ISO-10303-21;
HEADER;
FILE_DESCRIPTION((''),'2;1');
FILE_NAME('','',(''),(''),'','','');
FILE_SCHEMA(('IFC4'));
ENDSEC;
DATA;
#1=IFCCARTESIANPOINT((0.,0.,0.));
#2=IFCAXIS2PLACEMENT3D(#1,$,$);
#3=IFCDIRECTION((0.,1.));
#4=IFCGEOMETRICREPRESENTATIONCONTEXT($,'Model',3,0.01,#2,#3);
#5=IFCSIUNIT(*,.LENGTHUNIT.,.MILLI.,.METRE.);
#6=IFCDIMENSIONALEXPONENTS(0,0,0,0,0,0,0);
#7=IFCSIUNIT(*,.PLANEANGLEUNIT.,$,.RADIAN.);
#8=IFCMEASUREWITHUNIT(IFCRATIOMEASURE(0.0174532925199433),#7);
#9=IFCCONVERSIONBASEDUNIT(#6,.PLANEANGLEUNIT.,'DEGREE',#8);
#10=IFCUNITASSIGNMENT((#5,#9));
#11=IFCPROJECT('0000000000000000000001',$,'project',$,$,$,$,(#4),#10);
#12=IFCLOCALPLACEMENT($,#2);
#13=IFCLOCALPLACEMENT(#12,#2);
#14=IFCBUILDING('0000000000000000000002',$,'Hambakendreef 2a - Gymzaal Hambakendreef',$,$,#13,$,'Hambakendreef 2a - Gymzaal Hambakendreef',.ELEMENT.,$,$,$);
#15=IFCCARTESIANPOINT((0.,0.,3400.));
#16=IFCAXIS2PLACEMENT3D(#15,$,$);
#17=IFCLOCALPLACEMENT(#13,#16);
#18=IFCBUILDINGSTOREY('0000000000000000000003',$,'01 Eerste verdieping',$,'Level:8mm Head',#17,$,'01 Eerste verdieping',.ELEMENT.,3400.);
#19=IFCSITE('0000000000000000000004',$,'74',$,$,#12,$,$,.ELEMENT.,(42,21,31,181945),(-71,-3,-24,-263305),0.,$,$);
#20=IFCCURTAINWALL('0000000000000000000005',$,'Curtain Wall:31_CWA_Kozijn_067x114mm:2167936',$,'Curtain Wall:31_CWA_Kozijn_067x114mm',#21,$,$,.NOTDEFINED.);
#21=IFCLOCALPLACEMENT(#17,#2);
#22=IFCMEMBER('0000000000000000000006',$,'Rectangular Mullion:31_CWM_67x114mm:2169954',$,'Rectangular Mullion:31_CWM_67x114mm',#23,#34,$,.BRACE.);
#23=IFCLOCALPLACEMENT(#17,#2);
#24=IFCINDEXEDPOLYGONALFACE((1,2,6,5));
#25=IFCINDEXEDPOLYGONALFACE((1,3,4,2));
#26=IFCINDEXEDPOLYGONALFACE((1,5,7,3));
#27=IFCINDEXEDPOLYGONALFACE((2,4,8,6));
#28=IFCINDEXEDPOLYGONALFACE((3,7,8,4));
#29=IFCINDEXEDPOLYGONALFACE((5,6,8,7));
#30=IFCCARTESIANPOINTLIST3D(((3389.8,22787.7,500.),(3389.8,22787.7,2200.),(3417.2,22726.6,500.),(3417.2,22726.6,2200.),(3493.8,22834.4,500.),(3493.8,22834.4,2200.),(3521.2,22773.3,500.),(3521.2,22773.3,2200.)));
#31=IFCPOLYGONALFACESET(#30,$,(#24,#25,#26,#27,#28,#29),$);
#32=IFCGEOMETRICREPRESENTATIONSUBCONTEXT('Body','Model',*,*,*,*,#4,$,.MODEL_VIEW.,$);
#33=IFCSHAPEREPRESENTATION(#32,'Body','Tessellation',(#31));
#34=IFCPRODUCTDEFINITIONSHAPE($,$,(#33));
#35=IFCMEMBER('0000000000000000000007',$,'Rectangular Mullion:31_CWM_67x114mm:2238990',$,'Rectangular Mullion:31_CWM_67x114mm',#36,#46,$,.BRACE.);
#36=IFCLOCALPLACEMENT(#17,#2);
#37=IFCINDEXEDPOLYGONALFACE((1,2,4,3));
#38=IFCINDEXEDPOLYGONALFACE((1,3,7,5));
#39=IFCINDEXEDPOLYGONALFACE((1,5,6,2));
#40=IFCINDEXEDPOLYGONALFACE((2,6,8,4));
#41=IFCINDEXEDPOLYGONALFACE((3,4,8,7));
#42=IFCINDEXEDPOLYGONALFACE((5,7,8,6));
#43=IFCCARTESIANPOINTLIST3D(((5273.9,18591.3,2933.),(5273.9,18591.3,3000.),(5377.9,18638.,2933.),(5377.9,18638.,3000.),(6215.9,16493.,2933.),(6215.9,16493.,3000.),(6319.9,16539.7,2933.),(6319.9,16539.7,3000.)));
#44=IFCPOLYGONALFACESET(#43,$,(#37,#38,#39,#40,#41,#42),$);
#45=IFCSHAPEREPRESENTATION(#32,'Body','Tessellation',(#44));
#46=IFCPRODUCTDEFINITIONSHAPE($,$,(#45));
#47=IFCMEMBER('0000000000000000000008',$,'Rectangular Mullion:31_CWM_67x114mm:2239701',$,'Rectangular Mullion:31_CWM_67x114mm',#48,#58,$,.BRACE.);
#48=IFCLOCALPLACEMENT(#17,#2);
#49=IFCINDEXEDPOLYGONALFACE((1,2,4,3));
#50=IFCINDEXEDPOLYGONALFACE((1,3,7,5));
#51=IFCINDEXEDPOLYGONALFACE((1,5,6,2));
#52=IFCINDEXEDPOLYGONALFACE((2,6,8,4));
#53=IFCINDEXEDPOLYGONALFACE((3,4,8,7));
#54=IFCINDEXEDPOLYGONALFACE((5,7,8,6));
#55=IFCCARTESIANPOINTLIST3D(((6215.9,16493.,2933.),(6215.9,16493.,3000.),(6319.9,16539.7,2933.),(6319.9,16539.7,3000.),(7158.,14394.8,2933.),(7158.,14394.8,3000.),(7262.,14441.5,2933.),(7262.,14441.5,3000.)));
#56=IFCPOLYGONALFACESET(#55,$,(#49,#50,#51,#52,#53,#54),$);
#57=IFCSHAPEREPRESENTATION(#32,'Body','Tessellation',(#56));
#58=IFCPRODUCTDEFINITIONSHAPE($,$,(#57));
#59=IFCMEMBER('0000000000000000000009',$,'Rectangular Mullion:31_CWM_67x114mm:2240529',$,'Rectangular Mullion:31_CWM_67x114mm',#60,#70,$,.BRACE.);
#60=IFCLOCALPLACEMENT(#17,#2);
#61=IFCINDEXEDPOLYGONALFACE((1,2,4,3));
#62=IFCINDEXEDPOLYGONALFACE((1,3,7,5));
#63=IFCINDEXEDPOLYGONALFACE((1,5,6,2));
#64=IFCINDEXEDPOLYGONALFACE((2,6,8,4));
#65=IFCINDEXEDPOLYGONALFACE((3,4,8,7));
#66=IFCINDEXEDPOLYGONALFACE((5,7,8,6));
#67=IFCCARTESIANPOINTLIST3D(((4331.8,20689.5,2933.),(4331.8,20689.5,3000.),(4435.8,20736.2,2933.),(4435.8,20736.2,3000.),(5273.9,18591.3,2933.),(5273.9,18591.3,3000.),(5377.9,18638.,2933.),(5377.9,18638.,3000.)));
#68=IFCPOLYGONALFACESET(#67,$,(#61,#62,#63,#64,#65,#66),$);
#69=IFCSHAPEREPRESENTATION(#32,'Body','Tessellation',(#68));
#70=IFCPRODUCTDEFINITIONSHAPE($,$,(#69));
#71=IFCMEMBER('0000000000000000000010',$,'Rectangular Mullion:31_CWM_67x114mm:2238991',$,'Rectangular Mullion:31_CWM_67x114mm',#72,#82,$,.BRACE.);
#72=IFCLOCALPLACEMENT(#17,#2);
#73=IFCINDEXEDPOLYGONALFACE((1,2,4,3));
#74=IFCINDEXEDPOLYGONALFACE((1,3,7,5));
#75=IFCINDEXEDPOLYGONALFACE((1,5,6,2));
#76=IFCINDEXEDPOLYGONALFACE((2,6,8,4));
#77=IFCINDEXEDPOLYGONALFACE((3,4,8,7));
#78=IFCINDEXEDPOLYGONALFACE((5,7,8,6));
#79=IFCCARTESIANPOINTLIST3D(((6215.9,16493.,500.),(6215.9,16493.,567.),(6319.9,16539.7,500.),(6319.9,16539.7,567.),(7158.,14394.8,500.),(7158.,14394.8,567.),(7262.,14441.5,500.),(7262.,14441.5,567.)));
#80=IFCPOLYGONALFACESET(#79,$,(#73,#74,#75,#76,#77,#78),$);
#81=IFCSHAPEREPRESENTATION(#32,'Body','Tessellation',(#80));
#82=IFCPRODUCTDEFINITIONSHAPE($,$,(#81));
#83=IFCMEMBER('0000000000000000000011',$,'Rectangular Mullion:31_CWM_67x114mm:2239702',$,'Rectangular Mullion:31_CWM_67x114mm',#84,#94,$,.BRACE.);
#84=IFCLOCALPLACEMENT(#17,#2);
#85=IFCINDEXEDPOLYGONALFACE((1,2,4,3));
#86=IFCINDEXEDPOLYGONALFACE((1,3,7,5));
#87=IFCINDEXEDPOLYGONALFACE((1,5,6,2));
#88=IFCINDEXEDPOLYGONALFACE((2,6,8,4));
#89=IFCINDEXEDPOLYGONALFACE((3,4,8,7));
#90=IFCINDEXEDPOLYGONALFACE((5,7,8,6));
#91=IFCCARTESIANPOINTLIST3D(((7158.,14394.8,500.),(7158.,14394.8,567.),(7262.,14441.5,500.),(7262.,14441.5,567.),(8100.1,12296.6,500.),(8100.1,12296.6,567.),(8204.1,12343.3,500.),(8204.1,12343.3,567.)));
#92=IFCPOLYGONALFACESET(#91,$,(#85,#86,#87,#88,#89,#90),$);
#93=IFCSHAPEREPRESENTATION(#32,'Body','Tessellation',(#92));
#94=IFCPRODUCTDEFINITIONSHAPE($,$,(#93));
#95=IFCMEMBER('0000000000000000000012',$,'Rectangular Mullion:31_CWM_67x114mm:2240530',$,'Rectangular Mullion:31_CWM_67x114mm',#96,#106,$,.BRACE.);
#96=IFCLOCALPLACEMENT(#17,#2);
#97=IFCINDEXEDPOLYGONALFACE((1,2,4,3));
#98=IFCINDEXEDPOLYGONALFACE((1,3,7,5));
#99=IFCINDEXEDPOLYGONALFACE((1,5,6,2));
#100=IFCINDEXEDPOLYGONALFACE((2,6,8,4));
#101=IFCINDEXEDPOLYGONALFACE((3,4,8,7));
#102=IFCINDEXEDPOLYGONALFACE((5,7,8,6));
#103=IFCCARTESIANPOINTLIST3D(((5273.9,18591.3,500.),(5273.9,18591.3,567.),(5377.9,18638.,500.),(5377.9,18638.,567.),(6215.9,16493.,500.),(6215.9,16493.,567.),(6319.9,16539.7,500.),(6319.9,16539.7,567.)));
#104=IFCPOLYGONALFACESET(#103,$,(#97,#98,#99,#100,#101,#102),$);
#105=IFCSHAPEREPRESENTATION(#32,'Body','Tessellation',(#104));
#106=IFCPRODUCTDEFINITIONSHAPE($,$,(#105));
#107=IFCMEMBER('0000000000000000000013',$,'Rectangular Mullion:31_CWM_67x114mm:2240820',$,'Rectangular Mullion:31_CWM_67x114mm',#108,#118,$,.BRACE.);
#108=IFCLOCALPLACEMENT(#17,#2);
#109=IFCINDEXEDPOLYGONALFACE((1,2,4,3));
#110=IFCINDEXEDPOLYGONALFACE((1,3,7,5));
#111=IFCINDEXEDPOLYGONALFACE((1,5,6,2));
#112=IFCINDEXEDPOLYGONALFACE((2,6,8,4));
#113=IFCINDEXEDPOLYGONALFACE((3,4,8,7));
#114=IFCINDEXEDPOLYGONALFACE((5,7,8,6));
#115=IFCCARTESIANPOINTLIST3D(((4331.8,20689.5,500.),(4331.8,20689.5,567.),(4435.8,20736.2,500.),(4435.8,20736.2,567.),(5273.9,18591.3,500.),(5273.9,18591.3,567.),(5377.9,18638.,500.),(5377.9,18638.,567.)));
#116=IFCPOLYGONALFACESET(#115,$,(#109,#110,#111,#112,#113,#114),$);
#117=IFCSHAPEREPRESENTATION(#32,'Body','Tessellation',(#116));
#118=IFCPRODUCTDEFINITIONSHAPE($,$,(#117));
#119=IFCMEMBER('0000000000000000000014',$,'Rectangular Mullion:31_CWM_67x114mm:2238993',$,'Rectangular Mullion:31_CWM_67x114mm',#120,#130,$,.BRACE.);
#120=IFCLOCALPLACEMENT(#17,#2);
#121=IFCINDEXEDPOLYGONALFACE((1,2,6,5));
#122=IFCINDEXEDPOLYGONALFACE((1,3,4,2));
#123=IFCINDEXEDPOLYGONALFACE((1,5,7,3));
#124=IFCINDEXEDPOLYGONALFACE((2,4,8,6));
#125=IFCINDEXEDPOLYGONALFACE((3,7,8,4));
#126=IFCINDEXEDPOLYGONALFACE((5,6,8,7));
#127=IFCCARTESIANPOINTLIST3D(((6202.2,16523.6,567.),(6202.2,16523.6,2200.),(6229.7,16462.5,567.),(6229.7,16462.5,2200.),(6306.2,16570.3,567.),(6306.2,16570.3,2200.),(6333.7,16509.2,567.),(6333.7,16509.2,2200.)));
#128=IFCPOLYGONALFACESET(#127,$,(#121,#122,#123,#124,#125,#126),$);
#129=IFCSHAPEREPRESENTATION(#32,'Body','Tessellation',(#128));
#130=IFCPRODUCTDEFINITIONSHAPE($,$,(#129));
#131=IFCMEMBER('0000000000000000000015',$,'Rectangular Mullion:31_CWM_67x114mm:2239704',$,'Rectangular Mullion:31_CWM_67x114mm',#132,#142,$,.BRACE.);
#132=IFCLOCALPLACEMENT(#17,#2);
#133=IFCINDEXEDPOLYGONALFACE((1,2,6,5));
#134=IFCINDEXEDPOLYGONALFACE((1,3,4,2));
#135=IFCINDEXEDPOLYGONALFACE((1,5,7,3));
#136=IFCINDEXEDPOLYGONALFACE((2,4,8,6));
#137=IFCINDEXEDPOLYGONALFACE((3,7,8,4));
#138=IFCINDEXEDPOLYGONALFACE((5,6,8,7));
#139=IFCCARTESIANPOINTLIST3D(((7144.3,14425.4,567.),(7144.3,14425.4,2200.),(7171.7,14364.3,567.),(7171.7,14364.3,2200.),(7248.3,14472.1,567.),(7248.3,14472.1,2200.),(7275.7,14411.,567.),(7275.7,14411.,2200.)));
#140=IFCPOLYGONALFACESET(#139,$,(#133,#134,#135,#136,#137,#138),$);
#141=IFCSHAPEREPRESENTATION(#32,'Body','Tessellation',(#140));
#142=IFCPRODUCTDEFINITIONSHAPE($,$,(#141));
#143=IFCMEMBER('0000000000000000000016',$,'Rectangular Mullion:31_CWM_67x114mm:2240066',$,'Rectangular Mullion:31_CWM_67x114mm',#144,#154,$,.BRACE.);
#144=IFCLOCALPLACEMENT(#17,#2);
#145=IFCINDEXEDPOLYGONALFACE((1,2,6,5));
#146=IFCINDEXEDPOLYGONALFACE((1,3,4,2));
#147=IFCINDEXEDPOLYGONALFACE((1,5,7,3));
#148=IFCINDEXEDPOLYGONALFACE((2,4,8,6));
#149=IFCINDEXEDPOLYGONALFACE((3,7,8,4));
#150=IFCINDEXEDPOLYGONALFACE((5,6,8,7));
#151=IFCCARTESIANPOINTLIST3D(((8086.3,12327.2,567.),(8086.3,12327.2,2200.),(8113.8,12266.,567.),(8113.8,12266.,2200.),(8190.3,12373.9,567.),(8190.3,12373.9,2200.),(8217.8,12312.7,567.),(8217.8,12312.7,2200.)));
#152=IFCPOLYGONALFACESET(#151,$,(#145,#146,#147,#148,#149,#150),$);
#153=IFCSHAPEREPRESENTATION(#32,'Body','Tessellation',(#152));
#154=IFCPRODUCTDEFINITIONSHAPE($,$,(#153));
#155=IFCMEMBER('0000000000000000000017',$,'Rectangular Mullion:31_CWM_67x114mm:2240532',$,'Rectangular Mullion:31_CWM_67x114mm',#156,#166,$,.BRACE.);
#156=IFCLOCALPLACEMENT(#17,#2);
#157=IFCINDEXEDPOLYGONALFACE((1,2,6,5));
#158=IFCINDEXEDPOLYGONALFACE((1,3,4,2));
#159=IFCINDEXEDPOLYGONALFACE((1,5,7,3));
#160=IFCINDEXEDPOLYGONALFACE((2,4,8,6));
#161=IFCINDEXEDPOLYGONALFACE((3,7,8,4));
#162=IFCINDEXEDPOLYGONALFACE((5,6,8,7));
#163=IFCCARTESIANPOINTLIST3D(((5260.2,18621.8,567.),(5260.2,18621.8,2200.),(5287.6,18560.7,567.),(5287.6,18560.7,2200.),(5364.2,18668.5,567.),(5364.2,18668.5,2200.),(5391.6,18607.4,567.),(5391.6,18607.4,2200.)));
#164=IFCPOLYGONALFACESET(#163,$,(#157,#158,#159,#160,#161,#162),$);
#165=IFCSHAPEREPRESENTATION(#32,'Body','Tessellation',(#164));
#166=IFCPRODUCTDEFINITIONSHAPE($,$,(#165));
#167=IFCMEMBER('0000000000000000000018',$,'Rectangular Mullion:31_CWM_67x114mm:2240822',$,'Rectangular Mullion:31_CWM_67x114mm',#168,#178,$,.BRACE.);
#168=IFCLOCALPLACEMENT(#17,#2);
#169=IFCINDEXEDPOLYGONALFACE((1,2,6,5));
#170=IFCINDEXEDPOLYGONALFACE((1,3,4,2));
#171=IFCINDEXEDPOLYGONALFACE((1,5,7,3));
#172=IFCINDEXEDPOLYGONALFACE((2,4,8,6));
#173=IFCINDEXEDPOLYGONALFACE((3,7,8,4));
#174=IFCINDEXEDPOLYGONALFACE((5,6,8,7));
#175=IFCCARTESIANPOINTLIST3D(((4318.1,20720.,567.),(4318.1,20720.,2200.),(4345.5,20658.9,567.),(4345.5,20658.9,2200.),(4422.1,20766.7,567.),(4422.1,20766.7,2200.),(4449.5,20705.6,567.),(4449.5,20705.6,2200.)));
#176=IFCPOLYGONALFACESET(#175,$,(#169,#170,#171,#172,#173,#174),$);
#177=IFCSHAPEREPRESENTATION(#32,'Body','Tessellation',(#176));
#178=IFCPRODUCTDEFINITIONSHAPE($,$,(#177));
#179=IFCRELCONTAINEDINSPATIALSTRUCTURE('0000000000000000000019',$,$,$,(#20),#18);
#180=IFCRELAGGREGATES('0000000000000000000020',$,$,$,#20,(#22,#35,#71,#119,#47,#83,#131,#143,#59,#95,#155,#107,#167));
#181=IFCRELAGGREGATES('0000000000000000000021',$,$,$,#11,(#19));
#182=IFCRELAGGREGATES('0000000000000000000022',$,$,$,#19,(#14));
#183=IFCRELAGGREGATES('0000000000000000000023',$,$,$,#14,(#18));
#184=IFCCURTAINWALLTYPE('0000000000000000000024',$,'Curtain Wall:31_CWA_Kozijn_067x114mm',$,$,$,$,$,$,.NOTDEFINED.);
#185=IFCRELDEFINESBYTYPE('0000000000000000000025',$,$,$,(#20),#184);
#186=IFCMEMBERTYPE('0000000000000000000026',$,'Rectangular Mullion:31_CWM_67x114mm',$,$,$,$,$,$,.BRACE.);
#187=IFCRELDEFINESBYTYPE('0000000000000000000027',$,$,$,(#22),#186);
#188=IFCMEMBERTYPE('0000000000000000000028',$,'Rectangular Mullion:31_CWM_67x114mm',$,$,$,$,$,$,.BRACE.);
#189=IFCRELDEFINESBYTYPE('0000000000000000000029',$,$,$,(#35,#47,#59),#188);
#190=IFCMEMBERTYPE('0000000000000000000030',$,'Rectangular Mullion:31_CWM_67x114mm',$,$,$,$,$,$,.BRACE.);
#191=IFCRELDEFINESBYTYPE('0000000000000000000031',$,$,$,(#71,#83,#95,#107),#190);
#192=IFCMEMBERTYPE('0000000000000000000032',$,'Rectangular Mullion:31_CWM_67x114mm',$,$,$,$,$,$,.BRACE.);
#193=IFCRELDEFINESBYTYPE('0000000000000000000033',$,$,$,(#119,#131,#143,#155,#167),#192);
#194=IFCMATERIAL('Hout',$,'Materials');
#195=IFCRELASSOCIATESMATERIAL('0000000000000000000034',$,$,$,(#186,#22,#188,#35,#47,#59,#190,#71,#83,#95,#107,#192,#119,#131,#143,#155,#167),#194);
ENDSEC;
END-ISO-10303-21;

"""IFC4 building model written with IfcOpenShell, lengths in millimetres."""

from ifc_helpers import new_model, entity, si_unit, converted_unit, direction, frame, origin, place, context, subcontext, project, spatial, indexed_curve, outline, extrude, source, transform, mapped, material, type_object, type_shapes, element, aggregate, save


model = new_model("IFC4")

# Units and contexts
model_context = context("Model", 3, precision=0.01, world=origin(), true_north=direction((0.0, 1.0)))
body_context = subcontext(model_context, "Body", "Model", "MODEL_VIEW")
ifc_project = project(units=[si_unit("LENGTHUNIT", "METRE", prefix="MILLI"), converted_unit("PLANEANGLEUNIT", "DEGREE", entity("IfcRatioMeasure", 0.0174532925199433), si_unit("PLANEANGLEUNIT", "RADIAN"), dimensions=[0, 0, 0, 0, 0, 0, 0])], contexts=[model_context])

# Site, building, storey
site_placement = place(None, origin())
site = spatial("IfcSite", under=ifc_project, at=site_placement, Name="74", CompositionType="ELEMENT", RefLatitude=(42, 21, 31, 181945), RefLongitude=(-71, -3, -24, -263305), RefElevation=0.0)
building_placement = place(site_placement, origin())
building = spatial("IfcBuilding", under=site, at=building_placement, Name="Hambakendreef 2a - Gymzaal Hambakendreef", LongName="Hambakendreef 2a - Gymzaal Hambakendreef", CompositionType="ELEMENT")
storey_placement = place(building_placement, frame((0.0, 0.0, 3400.0)))
storey = spatial("IfcBuildingStorey", under=building, at=storey_placement, Name="01 Eerste verdieping", ObjectType="Level:8mm Head", LongName="01 Eerste verdieping", CompositionType="ELEMENT", Elevation=3400.0)

# Curtain wall, members
curtain_wall_type = type_object("IfcCurtainWallType", Name="Curtain Wall:31_CWA_Kozijn_067x114mm", PredefinedType="NOTDEFINED")
curtain_wall_placement = place(storey_placement, frame((0.0, 0.0, -3400.0)))
curtain_wall = element("IfcCurtainWall", 1, at=curtain_wall_placement, inside=storey, type_object=curtain_wall_type, Name="Curtain Wall:31_CWA_Kozijn_067x114mm:2167936", ObjectType="Curtain Wall:31_CWA_Kozijn_067x114mm", PredefinedType="NOTDEFINED")
ifc_material_1 = material(Name="Hout", Category="Materials")
member_type_1 = type_object("IfcMemberType", Name="Rectangular Mullion:31_CWM_67x114mm", PredefinedType="BRACE", material=ifc_material_1)
shared_shape_1 = source(origin(), body_context, "Body", "SweptSolid", [
    extrude(outline(indexed_curve([(-57.0, -33.5), (57.0, -33.5), (57.0, 33.5), (-57.0, 33.5), (-57.0, -33.5)], self_intersect=False)), frame((-33.5, 0.0, -1700.0), z_axis=(0.0, 0.0, 1.0), x_axis=(0.0, -1.0, 0.0)), (0.0, 0.0, 1.0), 1700.0),
])
type_shapes(member_type_1, [shared_shape_1])
member_1_placement = place(storey_placement, frame((3441.8, 22811.0, 2200.0), z_axis=(0.0, 0.0, 1.0), x_axis=(-0.40959, 0.91227, 0.0)))
member_1 = element("IfcMember", 2, at=member_1_placement, type_object=member_type_1, material=ifc_material_1, Name="Rectangular Mullion:31_CWM_67x114mm:2169954", ObjectType="Rectangular Mullion:31_CWM_67x114mm", PredefinedType="BRACE", context=body_context, shape_type="MappedRepresentation", body=[
    mapped(shared_shape_1, transform((0.0, 0.0, 0.0), scale=1.0)),
])
member_type_2 = type_object("IfcMemberType", Name="Rectangular Mullion:31_CWM_67x114mm", PredefinedType="BRACE", material=ifc_material_1)
shared_shape_2 = source(origin(), body_context, "Body", "SweptSolid", [
    extrude(outline(indexed_curve([(-57.0, -33.5), (57.0, -33.5), (57.0, 33.5), (-57.0, 33.5), (-57.0, -33.5)], self_intersect=False)), frame((-33.5, 0.0, -2300.0), z_axis=(0.0, 0.0, 1.0), x_axis=(0.0, -1.0, 0.0)), (0.0, 0.0, 1.0), 2300.0),
])
type_shapes(member_type_2, [shared_shape_2])
member_2_placement = place(storey_placement, frame((6267.9, 16516.4, 3000.0), z_axis=(0.40959, -0.91227, 0.0), x_axis=(0.0, 0.0, 1.0)))
member_2 = element("IfcMember", 3, at=member_2_placement, type_object=member_type_2, material=ifc_material_1, Name="Rectangular Mullion:31_CWM_67x114mm:2238990", ObjectType="Rectangular Mullion:31_CWM_67x114mm", PredefinedType="BRACE", context=body_context, shape_type="MappedRepresentation", body=[
    mapped(shared_shape_2, transform((0.0, 0.0, 0.0), scale=1.0)),
])
member_3_placement = place(storey_placement, frame((7210.0, 14418.2, 3000.0), z_axis=(0.40959, -0.91227, 0.0), x_axis=(0.0, 0.0, 1.0)))
member_3 = element("IfcMember", 4, at=member_3_placement, type_object=member_type_2, material=ifc_material_1, Name="Rectangular Mullion:31_CWM_67x114mm:2239701", ObjectType="Rectangular Mullion:31_CWM_67x114mm", PredefinedType="BRACE", context=body_context, shape_type="MappedRepresentation", body=[
    mapped(shared_shape_2, transform((0.0, 0.0, 0.0), scale=1.0)),
])
member_4_placement = place(storey_placement, frame((5325.9, 18614.6, 3000.0), z_axis=(0.40959, -0.91227, 0.0), x_axis=(0.0, 0.0, 1.0)))
member_4 = element("IfcMember", 5, at=member_4_placement, type_object=member_type_2, material=ifc_material_1, Name="Rectangular Mullion:31_CWM_67x114mm:2240529", ObjectType="Rectangular Mullion:31_CWM_67x114mm", PredefinedType="BRACE", context=body_context, shape_type="MappedRepresentation", body=[
    mapped(shared_shape_2, transform((0.0, 0.0, 0.0), scale=1.0)),
])
member_type_3 = type_object("IfcMemberType", Name="Rectangular Mullion:31_CWM_67x114mm", PredefinedType="BRACE", material=ifc_material_1)
shared_shape_3 = source(origin(), body_context, "Body", "SweptSolid", [
    extrude(outline(indexed_curve([(-57.0, -33.5), (57.0, -33.5), (57.0, 33.5), (-57.0, 33.5), (-57.0, -33.5)], self_intersect=False)), frame((-33.5, 0.0, -2300.0), z_axis=(0.0, 0.0, 1.0), x_axis=(0.0, -1.0, 0.0)), (0.0, 0.0, 1.0), 2300.0),
])
type_shapes(member_type_3, [shared_shape_3])
member_5_placement = place(storey_placement, frame((6267.9, 16516.4, 500.0), z_axis=(-0.40959, 0.91227, 0.0), x_axis=(0.0, 0.0, -1.0)))
member_5 = element("IfcMember", 6, at=member_5_placement, type_object=member_type_3, material=ifc_material_1, Name="Rectangular Mullion:31_CWM_67x114mm:2238991", ObjectType="Rectangular Mullion:31_CWM_67x114mm", PredefinedType="BRACE", context=body_context, shape_type="MappedRepresentation", body=[
    mapped(shared_shape_3, transform((0.0, 0.0, 0.0), scale=1.0)),
])
member_6_placement = place(storey_placement, frame((7210.0, 14418.2, 500.0), z_axis=(-0.40959, 0.91227, 0.0), x_axis=(0.0, 0.0, -1.0)))
member_6 = element("IfcMember", 7, at=member_6_placement, type_object=member_type_3, material=ifc_material_1, Name="Rectangular Mullion:31_CWM_67x114mm:2239702", ObjectType="Rectangular Mullion:31_CWM_67x114mm", PredefinedType="BRACE", context=body_context, shape_type="MappedRepresentation", body=[
    mapped(shared_shape_3, transform((0.0, 0.0, 0.0), scale=1.0)),
])
member_7_placement = place(storey_placement, frame((5325.9, 18614.6, 500.0), z_axis=(-0.40959, 0.91227, 0.0), x_axis=(0.0, 0.0, -1.0)))
member_7 = element("IfcMember", 8, at=member_7_placement, type_object=member_type_3, material=ifc_material_1, Name="Rectangular Mullion:31_CWM_67x114mm:2240530", ObjectType="Rectangular Mullion:31_CWM_67x114mm", PredefinedType="BRACE", context=body_context, shape_type="MappedRepresentation", body=[
    mapped(shared_shape_3, transform((0.0, 0.0, 0.0), scale=1.0)),
])
member_8_placement = place(storey_placement, frame((4383.8, 20712.8, 500.0), z_axis=(-0.40959, 0.91227, 0.0), x_axis=(0.0, 0.0, -1.0)))
member_8 = element("IfcMember", 9, at=member_8_placement, type_object=member_type_3, material=ifc_material_1, Name="Rectangular Mullion:31_CWM_67x114mm:2240820", ObjectType="Rectangular Mullion:31_CWM_67x114mm", PredefinedType="BRACE", context=body_context, shape_type="MappedRepresentation", body=[
    mapped(shared_shape_3, transform((0.0, 0.0, 0.0), scale=1.0)),
])
member_type_4 = type_object("IfcMemberType", Name="Rectangular Mullion:31_CWM_67x114mm", PredefinedType="BRACE", material=ifc_material_1)
shared_shape_4 = source(origin(), body_context, "Body", "SweptSolid", [
    extrude(outline(indexed_curve([(-57.0, -33.5), (57.0, -33.5), (57.0, 33.5), (-57.0, 33.5), (-57.0, -33.5)], self_intersect=False)), frame((0.0, 0.0, -1633.0), z_axis=(0.0, 0.0, 1.0), x_axis=(0.0, -1.0, 0.0)), (0.0, 0.0, 1.0), 1633.0),
])
type_shapes(member_type_4, [shared_shape_4])
member_9_placement = place(storey_placement, frame((6267.9, 16516.4, 567.0), z_axis=(0.0, 0.0, -1.0), x_axis=(0.40959, -0.91227, 0.0)))
member_9 = element("IfcMember", 10, at=member_9_placement, type_object=member_type_4, material=ifc_material_1, Name="Rectangular Mullion:31_CWM_67x114mm:2238993", ObjectType="Rectangular Mullion:31_CWM_67x114mm", PredefinedType="BRACE", context=body_context, shape_type="MappedRepresentation", body=[
    mapped(shared_shape_4, transform((0.0, 0.0, 0.0), scale=1.0)),
])
member_10_placement = place(storey_placement, frame((7210.0, 14418.2, 567.0), z_axis=(0.0, 0.0, -1.0), x_axis=(0.40959, -0.91227, 0.0)))
member_10 = element("IfcMember", 11, at=member_10_placement, type_object=member_type_4, material=ifc_material_1, Name="Rectangular Mullion:31_CWM_67x114mm:2239704", ObjectType="Rectangular Mullion:31_CWM_67x114mm", PredefinedType="BRACE", context=body_context, shape_type="MappedRepresentation", body=[
    mapped(shared_shape_4, transform((0.0, 0.0, 0.0), scale=1.0)),
])
member_11_placement = place(storey_placement, frame((8152.1, 12319.9, 567.0), z_axis=(0.0, 0.0, -1.0), x_axis=(0.40959, -0.91227, 0.0)))
member_11 = element("IfcMember", 12, at=member_11_placement, type_object=member_type_4, material=ifc_material_1, Name="Rectangular Mullion:31_CWM_67x114mm:2240066", ObjectType="Rectangular Mullion:31_CWM_67x114mm", PredefinedType="BRACE", context=body_context, shape_type="MappedRepresentation", body=[
    mapped(shared_shape_4, transform((0.0, 0.0, 0.0), scale=1.0)),
])
member_12_placement = place(storey_placement, frame((5325.9, 18614.6, 567.0), z_axis=(0.0, 0.0, -1.0), x_axis=(0.40959, -0.91227, 0.0)))
member_12 = element("IfcMember", 13, at=member_12_placement, type_object=member_type_4, material=ifc_material_1, Name="Rectangular Mullion:31_CWM_67x114mm:2240532", ObjectType="Rectangular Mullion:31_CWM_67x114mm", PredefinedType="BRACE", context=body_context, shape_type="MappedRepresentation", body=[
    mapped(shared_shape_4, transform((0.0, 0.0, 0.0), scale=1.0)),
])
member_13_placement = place(storey_placement, frame((4383.8, 20712.8, 567.0), z_axis=(0.0, 0.0, -1.0), x_axis=(0.40959, -0.91227, 0.0)))
member_13 = element("IfcMember", 14, at=member_13_placement, type_object=member_type_4, material=ifc_material_1, Name="Rectangular Mullion:31_CWM_67x114mm:2240822", ObjectType="Rectangular Mullion:31_CWM_67x114mm", PredefinedType="BRACE", context=body_context, shape_type="MappedRepresentation", body=[
    mapped(shared_shape_4, transform((0.0, 0.0, 0.0), scale=1.0)),
])
aggregate(curtain_wall, [member_1, member_2, member_5, member_9, member_3, member_6, member_10, member_11, member_4, member_7, member_12, member_8, member_13])

save(model, "model.ifc")
